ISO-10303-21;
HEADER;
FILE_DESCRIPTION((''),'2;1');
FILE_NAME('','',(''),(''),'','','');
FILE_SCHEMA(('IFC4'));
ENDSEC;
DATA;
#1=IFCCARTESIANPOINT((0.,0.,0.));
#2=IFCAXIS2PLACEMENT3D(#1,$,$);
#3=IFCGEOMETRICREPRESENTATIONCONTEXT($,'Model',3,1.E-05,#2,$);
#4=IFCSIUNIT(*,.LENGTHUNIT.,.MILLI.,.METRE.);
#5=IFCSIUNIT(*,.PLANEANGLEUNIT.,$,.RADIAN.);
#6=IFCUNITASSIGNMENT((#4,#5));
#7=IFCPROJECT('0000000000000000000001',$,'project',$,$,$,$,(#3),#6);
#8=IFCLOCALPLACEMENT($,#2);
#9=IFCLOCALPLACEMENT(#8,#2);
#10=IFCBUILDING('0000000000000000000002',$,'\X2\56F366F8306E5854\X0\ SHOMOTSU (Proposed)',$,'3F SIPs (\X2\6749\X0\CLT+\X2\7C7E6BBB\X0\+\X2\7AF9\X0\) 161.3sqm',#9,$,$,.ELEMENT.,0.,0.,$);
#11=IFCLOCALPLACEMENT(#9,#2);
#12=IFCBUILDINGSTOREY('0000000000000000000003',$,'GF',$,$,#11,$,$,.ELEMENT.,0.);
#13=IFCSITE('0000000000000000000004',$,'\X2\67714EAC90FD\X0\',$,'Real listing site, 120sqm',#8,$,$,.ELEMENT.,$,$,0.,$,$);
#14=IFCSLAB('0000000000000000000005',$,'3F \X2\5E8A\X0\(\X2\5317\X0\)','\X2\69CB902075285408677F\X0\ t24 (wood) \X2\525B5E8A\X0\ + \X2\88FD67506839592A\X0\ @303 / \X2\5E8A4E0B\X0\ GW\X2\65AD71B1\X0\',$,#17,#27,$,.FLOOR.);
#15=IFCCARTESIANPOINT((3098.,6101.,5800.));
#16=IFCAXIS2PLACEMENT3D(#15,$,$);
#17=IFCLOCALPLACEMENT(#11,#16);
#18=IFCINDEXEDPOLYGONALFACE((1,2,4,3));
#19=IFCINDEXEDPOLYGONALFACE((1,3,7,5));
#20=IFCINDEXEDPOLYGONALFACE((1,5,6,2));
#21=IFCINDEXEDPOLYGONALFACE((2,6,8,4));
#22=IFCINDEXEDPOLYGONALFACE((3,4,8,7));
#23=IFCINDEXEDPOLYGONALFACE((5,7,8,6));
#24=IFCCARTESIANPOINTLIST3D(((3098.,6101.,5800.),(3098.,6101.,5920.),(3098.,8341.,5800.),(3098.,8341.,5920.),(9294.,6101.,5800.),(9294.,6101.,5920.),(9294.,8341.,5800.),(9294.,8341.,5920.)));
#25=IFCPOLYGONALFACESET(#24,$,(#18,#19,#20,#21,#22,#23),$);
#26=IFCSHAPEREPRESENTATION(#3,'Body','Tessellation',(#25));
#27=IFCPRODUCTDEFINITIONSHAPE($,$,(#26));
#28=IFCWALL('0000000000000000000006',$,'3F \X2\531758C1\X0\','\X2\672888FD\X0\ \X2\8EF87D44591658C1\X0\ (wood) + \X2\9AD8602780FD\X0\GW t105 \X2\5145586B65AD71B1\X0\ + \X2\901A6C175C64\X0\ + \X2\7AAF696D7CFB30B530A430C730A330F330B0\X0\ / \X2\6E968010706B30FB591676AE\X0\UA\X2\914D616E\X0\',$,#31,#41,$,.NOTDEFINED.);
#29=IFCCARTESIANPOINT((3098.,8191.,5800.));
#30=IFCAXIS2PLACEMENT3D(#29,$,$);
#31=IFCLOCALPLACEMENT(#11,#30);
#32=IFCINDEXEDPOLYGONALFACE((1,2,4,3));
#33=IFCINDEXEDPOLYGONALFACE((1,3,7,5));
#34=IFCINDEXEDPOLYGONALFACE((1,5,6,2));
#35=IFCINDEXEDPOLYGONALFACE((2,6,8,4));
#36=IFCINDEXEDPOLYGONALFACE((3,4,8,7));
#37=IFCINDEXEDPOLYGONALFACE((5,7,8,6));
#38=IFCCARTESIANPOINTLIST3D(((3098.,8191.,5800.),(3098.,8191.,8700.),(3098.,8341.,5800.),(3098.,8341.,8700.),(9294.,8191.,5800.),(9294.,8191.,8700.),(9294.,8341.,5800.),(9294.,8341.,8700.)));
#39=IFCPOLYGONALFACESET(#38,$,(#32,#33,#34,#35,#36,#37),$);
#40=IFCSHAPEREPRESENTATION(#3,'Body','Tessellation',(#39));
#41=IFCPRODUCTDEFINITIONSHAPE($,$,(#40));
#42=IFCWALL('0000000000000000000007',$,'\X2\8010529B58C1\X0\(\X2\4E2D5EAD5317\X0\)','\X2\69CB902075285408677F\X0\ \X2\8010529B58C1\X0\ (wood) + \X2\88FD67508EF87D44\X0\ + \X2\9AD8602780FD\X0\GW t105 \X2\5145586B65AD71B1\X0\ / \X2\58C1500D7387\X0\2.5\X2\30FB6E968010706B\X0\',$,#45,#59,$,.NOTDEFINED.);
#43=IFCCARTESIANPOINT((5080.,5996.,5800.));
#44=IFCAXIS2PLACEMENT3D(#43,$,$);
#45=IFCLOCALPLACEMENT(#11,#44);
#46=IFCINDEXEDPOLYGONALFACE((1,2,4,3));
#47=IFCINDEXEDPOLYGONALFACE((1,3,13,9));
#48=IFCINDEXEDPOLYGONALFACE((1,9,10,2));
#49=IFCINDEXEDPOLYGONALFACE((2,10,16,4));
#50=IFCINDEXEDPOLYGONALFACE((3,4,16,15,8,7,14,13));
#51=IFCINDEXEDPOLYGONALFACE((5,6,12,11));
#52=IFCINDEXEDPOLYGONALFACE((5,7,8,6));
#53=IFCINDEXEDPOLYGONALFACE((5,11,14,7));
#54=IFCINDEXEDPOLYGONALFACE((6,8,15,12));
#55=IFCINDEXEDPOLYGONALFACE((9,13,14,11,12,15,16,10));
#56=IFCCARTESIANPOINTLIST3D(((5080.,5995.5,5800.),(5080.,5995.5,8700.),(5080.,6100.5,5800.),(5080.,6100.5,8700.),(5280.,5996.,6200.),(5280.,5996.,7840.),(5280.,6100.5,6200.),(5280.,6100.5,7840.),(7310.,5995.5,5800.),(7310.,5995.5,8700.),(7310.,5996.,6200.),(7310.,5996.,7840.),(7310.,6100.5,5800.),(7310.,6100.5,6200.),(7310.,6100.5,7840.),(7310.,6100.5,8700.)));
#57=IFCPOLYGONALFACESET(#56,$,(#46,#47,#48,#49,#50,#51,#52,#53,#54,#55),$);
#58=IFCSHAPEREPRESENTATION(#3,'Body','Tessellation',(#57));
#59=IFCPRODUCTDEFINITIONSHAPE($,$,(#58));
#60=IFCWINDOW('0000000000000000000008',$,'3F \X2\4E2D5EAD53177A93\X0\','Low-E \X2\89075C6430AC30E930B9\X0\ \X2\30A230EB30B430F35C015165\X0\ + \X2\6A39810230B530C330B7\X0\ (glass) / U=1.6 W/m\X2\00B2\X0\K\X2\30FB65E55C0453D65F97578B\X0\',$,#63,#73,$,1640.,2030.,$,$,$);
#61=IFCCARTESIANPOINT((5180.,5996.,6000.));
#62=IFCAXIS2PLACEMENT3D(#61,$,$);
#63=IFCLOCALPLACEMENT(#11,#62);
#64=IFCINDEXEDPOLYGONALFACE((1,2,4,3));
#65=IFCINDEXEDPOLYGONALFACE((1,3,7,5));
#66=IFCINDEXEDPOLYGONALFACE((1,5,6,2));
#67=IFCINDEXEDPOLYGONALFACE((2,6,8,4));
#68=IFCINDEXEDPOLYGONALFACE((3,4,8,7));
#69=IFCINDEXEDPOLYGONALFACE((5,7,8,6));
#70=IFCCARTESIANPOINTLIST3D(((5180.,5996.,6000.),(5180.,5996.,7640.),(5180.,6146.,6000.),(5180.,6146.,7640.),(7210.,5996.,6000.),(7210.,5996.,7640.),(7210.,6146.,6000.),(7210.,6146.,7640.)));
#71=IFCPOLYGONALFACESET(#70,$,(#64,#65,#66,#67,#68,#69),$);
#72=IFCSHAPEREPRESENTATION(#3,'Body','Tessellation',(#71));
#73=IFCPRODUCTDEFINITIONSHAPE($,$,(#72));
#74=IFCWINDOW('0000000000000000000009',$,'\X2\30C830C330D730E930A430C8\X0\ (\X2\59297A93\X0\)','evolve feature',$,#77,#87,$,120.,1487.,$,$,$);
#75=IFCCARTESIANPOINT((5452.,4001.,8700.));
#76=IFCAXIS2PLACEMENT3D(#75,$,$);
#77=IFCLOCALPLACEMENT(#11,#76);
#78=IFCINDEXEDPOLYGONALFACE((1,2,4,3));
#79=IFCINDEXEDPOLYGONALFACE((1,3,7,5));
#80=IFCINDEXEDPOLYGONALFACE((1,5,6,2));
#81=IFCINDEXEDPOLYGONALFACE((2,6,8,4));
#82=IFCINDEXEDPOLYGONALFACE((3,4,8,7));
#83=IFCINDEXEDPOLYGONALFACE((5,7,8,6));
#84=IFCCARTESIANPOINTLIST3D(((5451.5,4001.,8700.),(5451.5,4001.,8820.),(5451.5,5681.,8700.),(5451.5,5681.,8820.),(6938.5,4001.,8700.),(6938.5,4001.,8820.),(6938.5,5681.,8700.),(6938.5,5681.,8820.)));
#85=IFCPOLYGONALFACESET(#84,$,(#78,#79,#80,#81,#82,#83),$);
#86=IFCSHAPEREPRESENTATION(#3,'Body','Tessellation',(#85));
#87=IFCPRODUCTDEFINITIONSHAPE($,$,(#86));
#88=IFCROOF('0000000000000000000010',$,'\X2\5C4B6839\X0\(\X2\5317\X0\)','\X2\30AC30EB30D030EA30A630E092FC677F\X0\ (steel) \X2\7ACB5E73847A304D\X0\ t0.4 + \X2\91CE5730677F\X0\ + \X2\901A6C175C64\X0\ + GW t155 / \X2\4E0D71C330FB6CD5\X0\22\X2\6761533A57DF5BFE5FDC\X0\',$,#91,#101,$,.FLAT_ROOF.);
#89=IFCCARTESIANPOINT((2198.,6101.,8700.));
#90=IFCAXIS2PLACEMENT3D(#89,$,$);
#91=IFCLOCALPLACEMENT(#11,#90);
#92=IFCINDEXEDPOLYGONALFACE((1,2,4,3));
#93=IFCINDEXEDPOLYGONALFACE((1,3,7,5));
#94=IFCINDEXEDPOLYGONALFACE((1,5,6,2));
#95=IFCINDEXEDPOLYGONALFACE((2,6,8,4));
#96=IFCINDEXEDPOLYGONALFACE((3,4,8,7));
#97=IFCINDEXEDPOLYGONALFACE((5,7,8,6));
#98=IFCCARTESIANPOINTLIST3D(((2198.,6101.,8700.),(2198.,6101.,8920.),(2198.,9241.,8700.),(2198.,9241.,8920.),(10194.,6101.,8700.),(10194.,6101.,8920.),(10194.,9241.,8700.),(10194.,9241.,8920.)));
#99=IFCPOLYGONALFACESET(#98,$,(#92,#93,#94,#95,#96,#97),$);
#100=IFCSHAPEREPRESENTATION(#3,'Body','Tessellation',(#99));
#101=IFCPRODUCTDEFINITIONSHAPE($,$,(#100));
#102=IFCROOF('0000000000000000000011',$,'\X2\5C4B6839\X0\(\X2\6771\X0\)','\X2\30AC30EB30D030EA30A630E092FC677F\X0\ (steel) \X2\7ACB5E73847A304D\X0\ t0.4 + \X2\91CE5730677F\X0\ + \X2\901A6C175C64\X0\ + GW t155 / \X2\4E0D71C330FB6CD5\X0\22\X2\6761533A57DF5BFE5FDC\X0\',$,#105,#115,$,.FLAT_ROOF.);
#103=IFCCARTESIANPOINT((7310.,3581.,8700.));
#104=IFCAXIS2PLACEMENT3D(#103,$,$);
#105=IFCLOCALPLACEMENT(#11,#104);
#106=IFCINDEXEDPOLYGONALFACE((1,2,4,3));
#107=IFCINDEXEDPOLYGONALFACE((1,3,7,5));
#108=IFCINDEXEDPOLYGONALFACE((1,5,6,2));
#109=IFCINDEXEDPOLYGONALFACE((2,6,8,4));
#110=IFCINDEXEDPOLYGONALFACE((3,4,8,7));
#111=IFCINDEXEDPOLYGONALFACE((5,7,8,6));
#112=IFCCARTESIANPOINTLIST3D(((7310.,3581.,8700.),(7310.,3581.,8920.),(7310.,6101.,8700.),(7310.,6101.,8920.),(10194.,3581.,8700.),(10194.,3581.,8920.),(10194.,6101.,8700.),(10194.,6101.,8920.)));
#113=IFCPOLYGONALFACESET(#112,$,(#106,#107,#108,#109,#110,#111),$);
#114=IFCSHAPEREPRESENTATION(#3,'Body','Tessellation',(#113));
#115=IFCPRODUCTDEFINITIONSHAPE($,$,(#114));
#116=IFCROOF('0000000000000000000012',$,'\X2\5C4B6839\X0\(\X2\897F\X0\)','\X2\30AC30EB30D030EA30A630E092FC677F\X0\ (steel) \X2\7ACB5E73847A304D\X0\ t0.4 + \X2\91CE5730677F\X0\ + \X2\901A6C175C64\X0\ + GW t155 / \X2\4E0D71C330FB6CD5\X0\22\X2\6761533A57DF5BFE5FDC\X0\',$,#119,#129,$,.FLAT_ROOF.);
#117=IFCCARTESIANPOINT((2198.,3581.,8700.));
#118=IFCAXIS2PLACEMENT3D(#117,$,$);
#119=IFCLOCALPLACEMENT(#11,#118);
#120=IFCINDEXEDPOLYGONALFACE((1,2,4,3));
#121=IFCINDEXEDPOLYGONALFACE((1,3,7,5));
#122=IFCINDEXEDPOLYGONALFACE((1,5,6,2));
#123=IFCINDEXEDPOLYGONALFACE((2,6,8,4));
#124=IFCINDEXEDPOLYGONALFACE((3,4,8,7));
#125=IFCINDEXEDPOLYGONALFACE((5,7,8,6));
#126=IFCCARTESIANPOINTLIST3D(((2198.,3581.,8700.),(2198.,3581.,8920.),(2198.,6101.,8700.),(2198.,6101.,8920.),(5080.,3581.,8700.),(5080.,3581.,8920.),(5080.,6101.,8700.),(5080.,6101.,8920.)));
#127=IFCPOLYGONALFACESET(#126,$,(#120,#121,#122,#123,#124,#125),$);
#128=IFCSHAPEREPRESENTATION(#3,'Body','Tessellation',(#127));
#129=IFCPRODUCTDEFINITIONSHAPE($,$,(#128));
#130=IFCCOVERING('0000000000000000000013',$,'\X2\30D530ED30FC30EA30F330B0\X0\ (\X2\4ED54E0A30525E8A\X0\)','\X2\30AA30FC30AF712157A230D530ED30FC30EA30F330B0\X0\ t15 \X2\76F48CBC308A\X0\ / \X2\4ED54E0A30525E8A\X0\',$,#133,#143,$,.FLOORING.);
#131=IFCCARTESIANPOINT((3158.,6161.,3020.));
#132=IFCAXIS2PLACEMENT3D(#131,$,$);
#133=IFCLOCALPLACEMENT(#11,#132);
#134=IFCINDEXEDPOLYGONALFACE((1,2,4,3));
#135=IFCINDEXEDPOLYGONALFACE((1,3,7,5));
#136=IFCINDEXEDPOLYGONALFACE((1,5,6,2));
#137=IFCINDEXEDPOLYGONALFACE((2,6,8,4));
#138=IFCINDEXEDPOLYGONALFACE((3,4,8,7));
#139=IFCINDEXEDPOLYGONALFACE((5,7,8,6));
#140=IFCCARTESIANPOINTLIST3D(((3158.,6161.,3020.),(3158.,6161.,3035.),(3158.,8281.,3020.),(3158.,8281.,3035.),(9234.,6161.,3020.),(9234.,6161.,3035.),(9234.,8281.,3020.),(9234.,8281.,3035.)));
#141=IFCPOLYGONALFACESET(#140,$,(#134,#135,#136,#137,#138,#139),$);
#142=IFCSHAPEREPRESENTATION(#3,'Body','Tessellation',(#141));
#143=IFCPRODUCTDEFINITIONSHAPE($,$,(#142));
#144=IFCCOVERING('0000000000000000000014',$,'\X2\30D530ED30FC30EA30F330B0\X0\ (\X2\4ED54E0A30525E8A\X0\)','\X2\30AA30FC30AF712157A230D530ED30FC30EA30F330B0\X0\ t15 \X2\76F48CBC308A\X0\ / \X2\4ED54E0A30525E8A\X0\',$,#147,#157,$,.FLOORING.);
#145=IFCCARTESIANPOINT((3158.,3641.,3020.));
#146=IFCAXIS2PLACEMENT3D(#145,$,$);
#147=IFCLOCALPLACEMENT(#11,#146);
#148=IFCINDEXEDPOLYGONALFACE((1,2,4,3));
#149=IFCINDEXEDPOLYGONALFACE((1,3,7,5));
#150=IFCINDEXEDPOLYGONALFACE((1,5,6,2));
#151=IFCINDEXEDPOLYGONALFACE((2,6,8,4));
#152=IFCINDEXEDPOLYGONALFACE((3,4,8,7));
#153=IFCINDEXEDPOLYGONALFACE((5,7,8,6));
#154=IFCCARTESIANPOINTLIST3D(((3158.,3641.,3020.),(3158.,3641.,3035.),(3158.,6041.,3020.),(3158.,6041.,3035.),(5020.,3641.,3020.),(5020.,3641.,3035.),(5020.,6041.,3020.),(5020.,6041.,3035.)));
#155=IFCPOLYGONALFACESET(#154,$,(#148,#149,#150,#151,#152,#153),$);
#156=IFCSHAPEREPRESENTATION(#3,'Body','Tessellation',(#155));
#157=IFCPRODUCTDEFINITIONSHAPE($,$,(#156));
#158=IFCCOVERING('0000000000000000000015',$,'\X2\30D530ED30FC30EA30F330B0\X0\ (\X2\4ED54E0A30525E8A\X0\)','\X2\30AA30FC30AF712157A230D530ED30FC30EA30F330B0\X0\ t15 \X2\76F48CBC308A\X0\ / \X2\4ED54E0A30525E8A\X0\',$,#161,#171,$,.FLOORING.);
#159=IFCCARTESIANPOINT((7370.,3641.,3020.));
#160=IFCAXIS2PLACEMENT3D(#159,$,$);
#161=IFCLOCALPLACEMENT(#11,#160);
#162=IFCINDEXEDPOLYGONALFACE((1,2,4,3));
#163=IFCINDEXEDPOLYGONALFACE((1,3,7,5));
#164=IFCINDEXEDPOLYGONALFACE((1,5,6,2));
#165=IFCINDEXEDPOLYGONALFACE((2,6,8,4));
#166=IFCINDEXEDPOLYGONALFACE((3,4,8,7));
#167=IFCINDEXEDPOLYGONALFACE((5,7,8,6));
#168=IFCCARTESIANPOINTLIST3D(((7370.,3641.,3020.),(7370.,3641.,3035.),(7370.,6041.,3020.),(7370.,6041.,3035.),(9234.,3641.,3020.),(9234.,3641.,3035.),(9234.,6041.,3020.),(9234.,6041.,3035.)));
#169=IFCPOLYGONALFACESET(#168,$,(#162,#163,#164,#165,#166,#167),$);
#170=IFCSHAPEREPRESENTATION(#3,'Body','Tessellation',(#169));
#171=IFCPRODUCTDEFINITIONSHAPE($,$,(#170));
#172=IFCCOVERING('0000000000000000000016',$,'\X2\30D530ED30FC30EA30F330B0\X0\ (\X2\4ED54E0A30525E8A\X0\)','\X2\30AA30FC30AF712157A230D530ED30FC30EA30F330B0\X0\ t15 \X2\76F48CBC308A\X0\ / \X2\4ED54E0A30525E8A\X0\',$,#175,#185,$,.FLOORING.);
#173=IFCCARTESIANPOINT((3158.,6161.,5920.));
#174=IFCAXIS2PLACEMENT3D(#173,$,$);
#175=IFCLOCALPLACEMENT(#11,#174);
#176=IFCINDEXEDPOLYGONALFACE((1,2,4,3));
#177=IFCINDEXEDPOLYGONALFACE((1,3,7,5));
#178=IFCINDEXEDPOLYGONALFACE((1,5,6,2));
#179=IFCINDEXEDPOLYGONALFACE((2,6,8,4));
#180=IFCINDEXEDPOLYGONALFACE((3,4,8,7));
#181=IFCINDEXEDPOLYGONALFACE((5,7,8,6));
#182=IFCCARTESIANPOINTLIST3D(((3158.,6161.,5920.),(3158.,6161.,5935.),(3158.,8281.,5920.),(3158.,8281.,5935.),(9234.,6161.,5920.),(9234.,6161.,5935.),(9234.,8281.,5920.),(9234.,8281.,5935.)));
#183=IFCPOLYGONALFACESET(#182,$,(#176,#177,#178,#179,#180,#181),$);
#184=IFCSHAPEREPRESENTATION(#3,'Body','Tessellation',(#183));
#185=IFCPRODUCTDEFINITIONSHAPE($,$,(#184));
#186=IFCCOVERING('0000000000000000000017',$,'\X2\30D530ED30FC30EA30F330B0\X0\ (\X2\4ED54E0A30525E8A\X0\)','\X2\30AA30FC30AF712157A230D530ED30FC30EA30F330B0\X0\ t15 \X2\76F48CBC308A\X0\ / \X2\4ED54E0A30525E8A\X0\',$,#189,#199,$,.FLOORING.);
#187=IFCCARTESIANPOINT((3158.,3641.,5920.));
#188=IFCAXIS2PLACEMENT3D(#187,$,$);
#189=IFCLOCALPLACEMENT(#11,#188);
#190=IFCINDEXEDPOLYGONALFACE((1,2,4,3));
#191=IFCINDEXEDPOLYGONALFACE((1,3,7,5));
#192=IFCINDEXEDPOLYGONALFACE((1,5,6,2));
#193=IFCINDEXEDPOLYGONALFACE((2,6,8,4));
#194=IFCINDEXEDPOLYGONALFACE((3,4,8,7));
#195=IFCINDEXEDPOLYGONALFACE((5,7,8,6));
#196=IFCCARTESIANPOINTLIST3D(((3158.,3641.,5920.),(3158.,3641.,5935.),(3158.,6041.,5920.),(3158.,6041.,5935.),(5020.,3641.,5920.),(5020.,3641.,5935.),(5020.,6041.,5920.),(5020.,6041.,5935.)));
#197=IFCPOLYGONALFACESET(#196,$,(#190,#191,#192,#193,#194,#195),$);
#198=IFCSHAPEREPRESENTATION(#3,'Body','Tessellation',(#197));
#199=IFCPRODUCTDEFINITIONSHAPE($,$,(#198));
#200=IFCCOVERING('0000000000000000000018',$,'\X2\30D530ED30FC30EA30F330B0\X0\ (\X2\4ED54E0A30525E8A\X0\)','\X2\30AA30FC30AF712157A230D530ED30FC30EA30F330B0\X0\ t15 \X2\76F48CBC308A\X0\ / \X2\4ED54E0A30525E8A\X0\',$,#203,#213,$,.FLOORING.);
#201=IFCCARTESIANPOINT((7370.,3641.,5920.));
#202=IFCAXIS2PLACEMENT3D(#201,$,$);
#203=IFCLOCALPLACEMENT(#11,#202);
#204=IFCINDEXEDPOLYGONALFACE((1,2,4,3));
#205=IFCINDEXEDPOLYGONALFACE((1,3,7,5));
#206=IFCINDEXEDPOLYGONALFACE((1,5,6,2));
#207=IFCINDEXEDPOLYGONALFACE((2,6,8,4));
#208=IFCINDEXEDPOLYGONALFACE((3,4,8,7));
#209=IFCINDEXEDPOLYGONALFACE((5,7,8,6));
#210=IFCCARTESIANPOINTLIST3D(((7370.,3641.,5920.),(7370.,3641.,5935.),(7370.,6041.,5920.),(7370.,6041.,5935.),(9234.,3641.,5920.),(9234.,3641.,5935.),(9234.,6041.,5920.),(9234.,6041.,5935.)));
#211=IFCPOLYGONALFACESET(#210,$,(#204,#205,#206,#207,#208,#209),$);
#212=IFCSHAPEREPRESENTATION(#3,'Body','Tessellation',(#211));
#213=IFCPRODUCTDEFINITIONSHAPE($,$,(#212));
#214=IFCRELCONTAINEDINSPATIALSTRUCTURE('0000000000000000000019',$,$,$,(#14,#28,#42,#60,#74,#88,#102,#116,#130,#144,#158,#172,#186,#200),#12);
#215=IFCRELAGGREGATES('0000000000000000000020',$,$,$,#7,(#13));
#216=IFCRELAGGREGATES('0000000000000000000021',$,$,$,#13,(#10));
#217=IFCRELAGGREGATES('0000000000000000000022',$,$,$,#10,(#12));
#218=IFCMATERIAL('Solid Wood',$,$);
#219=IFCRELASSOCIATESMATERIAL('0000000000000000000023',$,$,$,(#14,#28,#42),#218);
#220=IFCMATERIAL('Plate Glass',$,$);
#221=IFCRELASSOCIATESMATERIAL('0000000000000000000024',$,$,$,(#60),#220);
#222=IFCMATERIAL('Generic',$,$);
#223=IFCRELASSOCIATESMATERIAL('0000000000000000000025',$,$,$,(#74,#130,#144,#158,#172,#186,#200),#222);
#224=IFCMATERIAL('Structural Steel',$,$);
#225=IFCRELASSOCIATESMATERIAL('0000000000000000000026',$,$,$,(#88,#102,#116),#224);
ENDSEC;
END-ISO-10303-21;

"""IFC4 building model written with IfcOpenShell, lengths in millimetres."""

from ifc_helpers import new_model, si_unit, frame, frame_2d, origin, place, context, project, spatial, rectangle, extrude, material, element, fill, save


model = new_model("IFC4")

# Units and contexts
model_context = context("Model", 3, precision=1e-05, world=origin())
ifc_project = project(units=[si_unit("LENGTHUNIT", "METRE", prefix="MILLI"), si_unit("PLANEANGLEUNIT", "RADIAN")], contexts=[model_context])

# Site, building, storey
site_placement = place(None, origin())
site = spatial("IfcSite", under=ifc_project, at=site_placement, Name="東京都", ObjectType="Real listing site, 120sqm", CompositionType="ELEMENT", RefElevation=0.0)
building_placement = place(site_placement, origin())
building = spatial("IfcBuilding", under=site, at=building_placement, Name="図書の塔 SHOMOTSU (Proposed)", ObjectType="3F SIPs (杉CLT+籾殻+竹) 161.3sqm", CompositionType="ELEMENT", ElevationOfRefHeight=0.0, ElevationOfTerrain=0.0)
storey_placement = place(building_placement, origin())
storey = spatial("IfcBuildingStorey", under=building, at=storey_placement, Name="GF", CompositionType="ELEMENT", Elevation=0.0)

# Slab
ifc_material_1 = material(Name="Solid Wood")
slab_placement = place(storey_placement, frame((3098.0, 6101.0, 5800.0)))
element("IfcSlab", 1, at=slab_placement, inside=storey, material=ifc_material_1, Name="3F 床(北)", Description="構造用合板 t24 (wood) 剛床 + 製材根太 @303 / 床下 GW断熱", PredefinedType="FLOOR", context=model_context, shape_type="SweptSolid", body=[
    extrude(rectangle(XDim=6196.0, YDim=2240.0, at=frame_2d((3098.0, 1120.0))), frame((3098.0, 6101.0, 5800.0)), (0.0, 0.0, 1.0), 120.0),
])

# Wall
wall_1_placement = place(storey_placement, frame((3098.0, 8191.0, 5800.0)))
element("IfcWall", 2, at=wall_1_placement, inside=storey, material=ifc_material_1, Name="3F 北壁", Description="木製 軸組外壁 (wood) + 高性能GW t105 充填断熱 + 通気層 + 窯業系サイディング / 準耐火・外皮UA配慮", PredefinedType="NOTDEFINED", context=model_context, shape_type="SweptSolid", body=[
    extrude(rectangle(XDim=6196.0, YDim=150.0, at=frame_2d((3098.0, 75.0))), frame((3098.0, 8191.0, 5800.0)), (0.0, 0.0, 1.0), 2900.0),
])

# Wall, opening, window
wall_2_placement = place(storey_placement, frame((5080.0, 5996.0, 5800.0)))
wall_2 = element("IfcWall", 3, at=wall_2_placement, inside=storey, material=ifc_material_1, Name="耐力壁(中庭北)", Description="構造用合板 耐力壁 (wood) + 製材軸組 + 高性能GW t105 充填断熱 / 壁倍率2.5・準耐火", PredefinedType="NOTDEFINED", context=model_context, shape_type="SweptSolid", body=[
    extrude(rectangle(XDim=2230.0, YDim=105.0, at=frame_2d((1115.0, 52.0))), frame((5080.0, 5996.0, 5800.0)), (0.0, 0.0, 1.0), 2900.0),
])
opening_placement = place(storey_placement, frame((5180.0, 5996.0, 6000.0)))
opening = element("IfcOpeningElement", 4, at=opening_placement, cuts=wall_2, PredefinedType="NOTDEFINED", context=model_context, shape_type="SweptSolid", body=[
    extrude(rectangle(XDim=2030.0, YDim=150.0, at=frame_2d((1015.0, 75.0))), frame((5180.0, 5996.0, 6000.0)), (0.0, 0.0, 1.0), 1640.0),
])
ifc_material_2 = material(Name="Plate Glass")
window_1_placement = place(storey_placement, frame((5180.0, 5996.0, 6000.0)))
window_1 = element("IfcWindow", 5, at=window_1_placement, inside=storey, material=ifc_material_2, Name="3F 中庭北窓", Description="Low-E 複層ガラス アルゴン封入 + 樹脂サッシ (glass) / U=1.6 W/m²K・日射取得型", OverallHeight=1640.0, OverallWidth=2030.0, context=model_context, shape_type="SweptSolid", body=[
    extrude(rectangle(XDim=2030.0, YDim=150.0, at=frame_2d((1015.0, 75.0))), frame((5180.0, 5996.0, 6000.0)), (0.0, 0.0, 1.0), 1640.0),
])
fill(opening, window_1)

# Window
ifc_material_3 = material(Name="Generic")
window_2_placement = place(storey_placement, frame((5452.0, 4001.0, 8700.0)))
element("IfcWindow", 6, at=window_2_placement, inside=storey, material=ifc_material_3, Name="トップライト (天窓)", Description="evolve feature", OverallHeight=120.0, OverallWidth=1487.0, context=model_context, shape_type="SweptSolid", body=[
    extrude(rectangle(XDim=1487.0, YDim=1680.0, at=frame_2d((743.0, 840.0))), frame((5452.0, 4001.0, 8700.0)), (0.0, 0.0, 1.0), 120.0),
])

# Roofs
ifc_material_4 = material(Name="Structural Steel")
roof_1_placement = place(storey_placement, frame((2198.0, 6101.0, 8700.0)))
element("IfcRoof", 7, at=roof_1_placement, inside=storey, material=ifc_material_4, Name="屋根(北)", Description="ガルバリウム鋼板 (steel) 立平葺き t0.4 + 野地板 + 通気層 + GW t155 / 不燃・法22条区域対応", PredefinedType="FLAT_ROOF", context=model_context, shape_type="SweptSolid", body=[
    extrude(rectangle(XDim=7996.0, YDim=3140.0, at=frame_2d((3998.0, 1570.0))), frame((2198.0, 6101.0, 8700.0)), (0.0, 0.0, 1.0), 220.0),
])
roof_2_placement = place(storey_placement, frame((7310.0, 3581.0, 8700.0)))
element("IfcRoof", 8, at=roof_2_placement, inside=storey, material=ifc_material_4, Name="屋根(東)", Description="ガルバリウム鋼板 (steel) 立平葺き t0.4 + 野地板 + 通気層 + GW t155 / 不燃・法22条区域対応", PredefinedType="FLAT_ROOF", context=model_context, shape_type="SweptSolid", body=[
    extrude(rectangle(XDim=2884.0, YDim=2520.0, at=frame_2d((1442.0, 1260.0))), frame((7310.0, 3581.0, 8700.0)), (0.0, 0.0, 1.0), 220.0),
])
roof_3_placement = place(storey_placement, frame((2198.0, 3581.0, 8700.0)))
element("IfcRoof", 9, at=roof_3_placement, inside=storey, material=ifc_material_4, Name="屋根(西)", Description="ガルバリウム鋼板 (steel) 立平葺き t0.4 + 野地板 + 通気層 + GW t155 / 不燃・法22条区域対応", PredefinedType="FLAT_ROOF", context=model_context, shape_type="SweptSolid", body=[
    extrude(rectangle(XDim=2882.0, YDim=2520.0, at=frame_2d((1441.0, 1260.0))), frame((2198.0, 3581.0, 8700.0)), (0.0, 0.0, 1.0), 220.0),
])

# Coverings
covering_1_placement = place(storey_placement, frame((3158.0, 6161.0, 3020.0)))
element("IfcCovering", 10, at=covering_1_placement, inside=storey, material=ifc_material_3, Name="フローリング (仕上げ床)", Description="オーク無垢フローリング t15 直貼り / 仕上げ床", PredefinedType="FLOORING", context=model_context, shape_type="SweptSolid", body=[
    extrude(rectangle(XDim=6076.0, YDim=2120.0, at=frame_2d((3038.0, 1060.0))), frame((3158.0, 6161.0, 3020.0)), (0.0, 0.0, 1.0), 15.0),
])
covering_2_placement = place(storey_placement, frame((3158.0, 3641.0, 3020.0)))
element("IfcCovering", 11, at=covering_2_placement, inside=storey, material=ifc_material_3, Name="フローリング (仕上げ床)", Description="オーク無垢フローリング t15 直貼り / 仕上げ床", PredefinedType="FLOORING", context=model_context, shape_type="SweptSolid", body=[
    extrude(rectangle(XDim=1862.0, YDim=2400.0, at=frame_2d((931.0, 1200.0))), frame((3158.0, 3641.0, 3020.0)), (0.0, 0.0, 1.0), 15.0),
])
covering_3_placement = place(storey_placement, frame((7370.0, 3641.0, 3020.0)))
element("IfcCovering", 12, at=covering_3_placement, inside=storey, material=ifc_material_3, Name="フローリング (仕上げ床)", Description="オーク無垢フローリング t15 直貼り / 仕上げ床", PredefinedType="FLOORING", context=model_context, shape_type="SweptSolid", body=[
    extrude(rectangle(XDim=1864.0, YDim=2400.0, at=frame_2d((932.0, 1200.0))), frame((7370.0, 3641.0, 3020.0)), (0.0, 0.0, 1.0), 15.0),
])
covering_4_placement = place(storey_placement, frame((3158.0, 6161.0, 5920.0)))
element("IfcCovering", 13, at=covering_4_placement, inside=storey, material=ifc_material_3, Name="フローリング (仕上げ床)", Description="オーク無垢フローリング t15 直貼り / 仕上げ床", PredefinedType="FLOORING", context=model_context, shape_type="SweptSolid", body=[
    extrude(rectangle(XDim=6076.0, YDim=2120.0, at=frame_2d((3038.0, 1060.0))), frame((3158.0, 6161.0, 5920.0)), (0.0, 0.0, 1.0), 15.0),
])
covering_5_placement = place(storey_placement, frame((3158.0, 3641.0, 5920.0)))
element("IfcCovering", 14, at=covering_5_placement, inside=storey, material=ifc_material_3, Name="フローリング (仕上げ床)", Description="オーク無垢フローリング t15 直貼り / 仕上げ床", PredefinedType="FLOORING", context=model_context, shape_type="SweptSolid", body=[
    extrude(rectangle(XDim=1862.0, YDim=2400.0, at=frame_2d((931.0, 1200.0))), frame((3158.0, 3641.0, 5920.0)), (0.0, 0.0, 1.0), 15.0),
])
covering_6_placement = place(storey_placement, frame((7370.0, 3641.0, 5920.0)))
element("IfcCovering", 15, at=covering_6_placement, inside=storey, material=ifc_material_3, Name="フローリング (仕上げ床)", Description="オーク無垢フローリング t15 直貼り / 仕上げ床", PredefinedType="FLOORING", context=model_context, shape_type="SweptSolid", body=[
    extrude(rectangle(XDim=1864.0, YDim=2400.0, at=frame_2d((932.0, 1200.0))), frame((7370.0, 3641.0, 5920.0)), (0.0, 0.0, 1.0), 15.0),
])

save(model, "model.ifc")
